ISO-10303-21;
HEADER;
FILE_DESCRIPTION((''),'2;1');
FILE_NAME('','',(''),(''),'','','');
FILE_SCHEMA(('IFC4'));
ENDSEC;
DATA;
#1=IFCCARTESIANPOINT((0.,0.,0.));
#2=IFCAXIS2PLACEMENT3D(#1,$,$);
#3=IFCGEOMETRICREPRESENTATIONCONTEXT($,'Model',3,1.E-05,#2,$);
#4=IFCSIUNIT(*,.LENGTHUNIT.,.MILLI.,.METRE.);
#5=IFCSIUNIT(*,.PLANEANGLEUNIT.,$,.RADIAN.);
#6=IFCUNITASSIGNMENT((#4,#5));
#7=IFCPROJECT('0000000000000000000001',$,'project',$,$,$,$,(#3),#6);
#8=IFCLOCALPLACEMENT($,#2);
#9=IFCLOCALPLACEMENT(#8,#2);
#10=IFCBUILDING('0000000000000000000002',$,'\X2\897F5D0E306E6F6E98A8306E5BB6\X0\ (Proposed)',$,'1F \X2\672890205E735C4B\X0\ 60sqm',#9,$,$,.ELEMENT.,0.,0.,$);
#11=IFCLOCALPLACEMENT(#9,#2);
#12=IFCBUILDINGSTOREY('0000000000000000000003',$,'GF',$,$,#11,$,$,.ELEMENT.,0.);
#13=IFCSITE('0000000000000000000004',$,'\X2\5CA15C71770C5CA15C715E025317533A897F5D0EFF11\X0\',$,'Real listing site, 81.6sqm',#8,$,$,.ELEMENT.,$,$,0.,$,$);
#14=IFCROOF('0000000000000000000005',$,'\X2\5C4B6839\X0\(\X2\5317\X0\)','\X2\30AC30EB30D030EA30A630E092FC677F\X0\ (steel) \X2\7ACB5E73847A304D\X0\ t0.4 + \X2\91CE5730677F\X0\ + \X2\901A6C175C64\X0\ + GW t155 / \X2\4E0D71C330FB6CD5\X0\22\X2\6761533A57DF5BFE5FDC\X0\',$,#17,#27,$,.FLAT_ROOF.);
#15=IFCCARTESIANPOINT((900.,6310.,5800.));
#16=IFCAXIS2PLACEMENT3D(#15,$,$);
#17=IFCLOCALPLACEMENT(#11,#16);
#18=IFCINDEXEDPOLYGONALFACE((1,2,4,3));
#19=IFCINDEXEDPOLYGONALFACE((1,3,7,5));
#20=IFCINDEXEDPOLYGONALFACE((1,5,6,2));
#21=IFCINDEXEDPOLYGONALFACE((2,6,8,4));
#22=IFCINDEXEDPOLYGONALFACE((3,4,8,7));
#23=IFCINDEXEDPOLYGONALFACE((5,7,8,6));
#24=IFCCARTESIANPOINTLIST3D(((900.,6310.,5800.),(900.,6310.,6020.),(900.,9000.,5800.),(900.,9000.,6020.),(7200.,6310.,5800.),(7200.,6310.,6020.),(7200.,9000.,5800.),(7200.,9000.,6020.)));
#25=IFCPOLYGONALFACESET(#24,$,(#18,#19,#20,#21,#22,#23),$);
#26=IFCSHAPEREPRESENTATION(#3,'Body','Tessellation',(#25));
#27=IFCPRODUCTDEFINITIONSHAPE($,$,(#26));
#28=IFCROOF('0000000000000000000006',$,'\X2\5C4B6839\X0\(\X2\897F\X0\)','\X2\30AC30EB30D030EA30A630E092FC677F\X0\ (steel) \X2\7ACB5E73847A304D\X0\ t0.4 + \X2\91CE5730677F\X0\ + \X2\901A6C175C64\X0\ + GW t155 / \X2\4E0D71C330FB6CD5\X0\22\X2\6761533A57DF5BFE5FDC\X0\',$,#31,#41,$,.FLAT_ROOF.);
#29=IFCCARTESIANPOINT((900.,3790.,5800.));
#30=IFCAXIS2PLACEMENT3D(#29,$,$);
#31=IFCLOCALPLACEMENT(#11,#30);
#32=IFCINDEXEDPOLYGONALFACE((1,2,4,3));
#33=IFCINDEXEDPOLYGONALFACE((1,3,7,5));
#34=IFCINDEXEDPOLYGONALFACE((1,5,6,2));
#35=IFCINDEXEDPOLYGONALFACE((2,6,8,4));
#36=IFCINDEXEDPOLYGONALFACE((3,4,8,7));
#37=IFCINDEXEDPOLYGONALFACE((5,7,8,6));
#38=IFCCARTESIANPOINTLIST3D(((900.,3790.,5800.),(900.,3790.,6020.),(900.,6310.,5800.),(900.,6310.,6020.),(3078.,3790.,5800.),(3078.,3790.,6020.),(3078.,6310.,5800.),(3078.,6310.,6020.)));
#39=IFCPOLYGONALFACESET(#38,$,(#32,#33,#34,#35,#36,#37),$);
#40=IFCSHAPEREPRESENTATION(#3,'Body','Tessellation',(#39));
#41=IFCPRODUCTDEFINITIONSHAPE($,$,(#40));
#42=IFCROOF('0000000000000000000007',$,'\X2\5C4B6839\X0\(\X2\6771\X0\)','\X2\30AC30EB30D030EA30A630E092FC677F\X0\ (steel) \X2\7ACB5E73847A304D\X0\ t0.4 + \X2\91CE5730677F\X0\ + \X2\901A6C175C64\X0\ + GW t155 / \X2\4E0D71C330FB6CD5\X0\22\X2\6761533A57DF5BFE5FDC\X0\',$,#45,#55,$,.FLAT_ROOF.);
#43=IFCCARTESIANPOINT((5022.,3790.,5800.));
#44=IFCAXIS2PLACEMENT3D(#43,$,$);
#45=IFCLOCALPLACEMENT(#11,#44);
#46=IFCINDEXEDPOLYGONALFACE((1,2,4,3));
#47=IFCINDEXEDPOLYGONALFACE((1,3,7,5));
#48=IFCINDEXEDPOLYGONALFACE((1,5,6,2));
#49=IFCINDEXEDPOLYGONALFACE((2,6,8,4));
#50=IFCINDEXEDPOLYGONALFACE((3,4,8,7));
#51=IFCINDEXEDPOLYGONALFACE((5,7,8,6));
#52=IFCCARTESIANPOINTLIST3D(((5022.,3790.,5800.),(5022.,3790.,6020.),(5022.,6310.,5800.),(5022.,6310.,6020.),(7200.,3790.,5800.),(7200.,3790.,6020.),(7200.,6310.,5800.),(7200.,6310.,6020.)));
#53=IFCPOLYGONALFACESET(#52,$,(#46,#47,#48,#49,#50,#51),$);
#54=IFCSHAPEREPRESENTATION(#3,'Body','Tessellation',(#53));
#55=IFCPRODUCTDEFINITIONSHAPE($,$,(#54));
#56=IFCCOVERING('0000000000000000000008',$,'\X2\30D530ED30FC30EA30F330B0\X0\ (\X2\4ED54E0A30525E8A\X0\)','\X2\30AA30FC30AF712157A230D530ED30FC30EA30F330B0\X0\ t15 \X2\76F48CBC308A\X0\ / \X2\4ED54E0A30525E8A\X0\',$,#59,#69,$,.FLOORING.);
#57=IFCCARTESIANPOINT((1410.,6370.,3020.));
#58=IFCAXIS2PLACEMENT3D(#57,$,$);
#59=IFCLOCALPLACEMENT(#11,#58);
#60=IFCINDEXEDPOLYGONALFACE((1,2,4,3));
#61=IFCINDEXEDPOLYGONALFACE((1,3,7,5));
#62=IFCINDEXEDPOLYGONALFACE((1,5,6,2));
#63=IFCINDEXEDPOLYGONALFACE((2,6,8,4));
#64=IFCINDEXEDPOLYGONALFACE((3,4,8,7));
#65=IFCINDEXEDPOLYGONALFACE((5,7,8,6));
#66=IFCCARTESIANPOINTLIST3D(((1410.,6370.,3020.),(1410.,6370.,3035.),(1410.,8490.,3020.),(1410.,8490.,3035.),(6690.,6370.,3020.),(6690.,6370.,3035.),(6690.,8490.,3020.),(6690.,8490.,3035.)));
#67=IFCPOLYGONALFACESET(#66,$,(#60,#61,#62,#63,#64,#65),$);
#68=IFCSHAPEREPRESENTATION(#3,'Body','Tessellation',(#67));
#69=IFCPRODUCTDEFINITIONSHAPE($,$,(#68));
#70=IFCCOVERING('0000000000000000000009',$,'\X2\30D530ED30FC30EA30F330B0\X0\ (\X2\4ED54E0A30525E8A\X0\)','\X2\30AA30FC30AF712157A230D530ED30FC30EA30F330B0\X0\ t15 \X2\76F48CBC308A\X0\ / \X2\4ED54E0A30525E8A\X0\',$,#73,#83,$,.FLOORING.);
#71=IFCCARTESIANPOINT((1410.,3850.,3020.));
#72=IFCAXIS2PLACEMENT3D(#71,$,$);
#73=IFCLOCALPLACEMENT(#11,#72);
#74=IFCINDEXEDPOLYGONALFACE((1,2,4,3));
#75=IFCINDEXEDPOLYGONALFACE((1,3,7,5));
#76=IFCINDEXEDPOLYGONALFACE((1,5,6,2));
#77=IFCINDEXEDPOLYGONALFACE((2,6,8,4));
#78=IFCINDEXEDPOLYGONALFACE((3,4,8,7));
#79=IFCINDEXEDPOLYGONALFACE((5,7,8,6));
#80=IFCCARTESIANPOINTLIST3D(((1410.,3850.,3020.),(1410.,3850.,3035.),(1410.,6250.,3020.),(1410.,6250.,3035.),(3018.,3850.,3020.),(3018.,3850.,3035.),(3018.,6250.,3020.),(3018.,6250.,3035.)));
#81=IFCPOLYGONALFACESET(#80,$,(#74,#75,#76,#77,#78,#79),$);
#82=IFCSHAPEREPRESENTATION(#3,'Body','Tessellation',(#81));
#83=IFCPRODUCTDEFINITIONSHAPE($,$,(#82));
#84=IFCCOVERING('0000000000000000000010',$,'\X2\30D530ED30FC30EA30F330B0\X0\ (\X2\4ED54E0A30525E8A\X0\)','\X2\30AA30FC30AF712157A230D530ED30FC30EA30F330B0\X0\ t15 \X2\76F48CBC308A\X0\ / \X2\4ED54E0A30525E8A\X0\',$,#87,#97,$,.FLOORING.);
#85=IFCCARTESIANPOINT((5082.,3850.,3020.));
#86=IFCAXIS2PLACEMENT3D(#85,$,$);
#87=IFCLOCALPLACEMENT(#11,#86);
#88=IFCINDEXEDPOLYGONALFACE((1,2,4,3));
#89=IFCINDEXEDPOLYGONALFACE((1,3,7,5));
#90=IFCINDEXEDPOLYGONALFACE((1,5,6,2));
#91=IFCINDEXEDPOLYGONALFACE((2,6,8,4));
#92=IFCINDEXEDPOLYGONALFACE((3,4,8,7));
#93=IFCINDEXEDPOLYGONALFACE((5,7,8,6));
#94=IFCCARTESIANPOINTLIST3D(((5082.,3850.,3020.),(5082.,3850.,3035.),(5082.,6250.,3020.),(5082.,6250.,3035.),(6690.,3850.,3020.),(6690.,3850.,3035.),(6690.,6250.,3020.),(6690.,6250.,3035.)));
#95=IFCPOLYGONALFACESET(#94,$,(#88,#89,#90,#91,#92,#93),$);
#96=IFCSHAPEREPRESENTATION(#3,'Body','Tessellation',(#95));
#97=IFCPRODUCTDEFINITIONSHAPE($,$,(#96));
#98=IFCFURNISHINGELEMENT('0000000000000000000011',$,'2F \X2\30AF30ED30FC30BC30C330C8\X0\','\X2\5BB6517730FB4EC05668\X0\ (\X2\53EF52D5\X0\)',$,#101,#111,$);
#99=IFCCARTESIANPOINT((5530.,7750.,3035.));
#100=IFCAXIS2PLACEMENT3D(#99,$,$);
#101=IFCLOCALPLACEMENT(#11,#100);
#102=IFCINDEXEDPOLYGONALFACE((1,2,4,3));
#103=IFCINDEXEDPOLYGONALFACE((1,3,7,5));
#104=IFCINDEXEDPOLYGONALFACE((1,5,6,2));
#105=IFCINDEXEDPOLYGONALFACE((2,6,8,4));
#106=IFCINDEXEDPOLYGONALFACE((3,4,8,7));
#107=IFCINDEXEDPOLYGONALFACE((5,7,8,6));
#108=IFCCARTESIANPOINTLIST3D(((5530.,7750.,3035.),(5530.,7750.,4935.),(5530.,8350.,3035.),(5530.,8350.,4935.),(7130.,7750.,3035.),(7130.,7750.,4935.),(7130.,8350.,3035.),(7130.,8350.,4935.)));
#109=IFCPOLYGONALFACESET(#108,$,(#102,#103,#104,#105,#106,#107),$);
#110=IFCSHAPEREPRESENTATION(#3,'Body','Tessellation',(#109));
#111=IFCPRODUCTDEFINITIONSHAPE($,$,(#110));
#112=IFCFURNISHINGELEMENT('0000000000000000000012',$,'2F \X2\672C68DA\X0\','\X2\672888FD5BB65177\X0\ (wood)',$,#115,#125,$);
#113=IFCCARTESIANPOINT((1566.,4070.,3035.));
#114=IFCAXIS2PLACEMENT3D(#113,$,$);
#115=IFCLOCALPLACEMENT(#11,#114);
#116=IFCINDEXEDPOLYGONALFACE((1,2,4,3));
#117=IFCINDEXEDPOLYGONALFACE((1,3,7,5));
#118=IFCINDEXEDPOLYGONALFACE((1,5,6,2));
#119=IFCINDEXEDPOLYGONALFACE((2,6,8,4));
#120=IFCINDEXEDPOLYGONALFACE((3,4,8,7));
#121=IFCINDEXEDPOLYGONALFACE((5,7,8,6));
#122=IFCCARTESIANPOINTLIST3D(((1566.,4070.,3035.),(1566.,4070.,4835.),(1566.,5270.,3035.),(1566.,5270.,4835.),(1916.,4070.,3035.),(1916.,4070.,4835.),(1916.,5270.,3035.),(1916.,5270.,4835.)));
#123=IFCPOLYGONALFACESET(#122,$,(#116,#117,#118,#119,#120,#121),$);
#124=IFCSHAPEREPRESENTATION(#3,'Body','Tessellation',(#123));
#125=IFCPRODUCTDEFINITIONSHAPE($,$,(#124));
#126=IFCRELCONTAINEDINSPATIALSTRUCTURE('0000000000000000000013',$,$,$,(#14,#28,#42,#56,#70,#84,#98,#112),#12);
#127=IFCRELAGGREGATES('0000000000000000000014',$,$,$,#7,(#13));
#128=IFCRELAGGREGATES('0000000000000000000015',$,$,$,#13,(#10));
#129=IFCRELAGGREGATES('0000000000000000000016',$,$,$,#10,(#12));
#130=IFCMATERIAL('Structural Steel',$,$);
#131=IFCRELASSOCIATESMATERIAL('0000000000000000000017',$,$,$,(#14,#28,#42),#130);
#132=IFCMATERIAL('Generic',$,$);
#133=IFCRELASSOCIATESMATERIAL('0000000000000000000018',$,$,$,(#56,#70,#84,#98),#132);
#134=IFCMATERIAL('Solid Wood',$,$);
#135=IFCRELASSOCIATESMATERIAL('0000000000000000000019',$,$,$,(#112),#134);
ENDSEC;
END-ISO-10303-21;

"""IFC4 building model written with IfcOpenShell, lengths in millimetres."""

from ifc_helpers import new_model, si_unit, frame, frame_2d, origin, place, context, project, spatial, rectangle, extrude, material, element, save


model = new_model("IFC4")

# Units and contexts
model_context = context("Model", 3, precision=1e-05, world=origin())
ifc_project = project(units=[si_unit("LENGTHUNIT", "METRE", prefix="MILLI"), si_unit("PLANEANGLEUNIT", "RADIAN")], contexts=[model_context])

# Site, building, storey
site_placement = place(None, origin())
site = spatial("IfcSite", under=ifc_project, at=site_placement, Name="岡山県岡山市北区西崎１", ObjectType="Real listing site, 81.6sqm", CompositionType="ELEMENT", RefElevation=0.0)
building_placement = place(site_placement, origin())
building = spatial("IfcBuilding", under=site, at=building_placement, Name="西崎の潮風の家 (Proposed)", ObjectType="1F 木造平屋 60sqm", CompositionType="ELEMENT", ElevationOfRefHeight=0.0, ElevationOfTerrain=0.0)
storey_placement = place(building_placement, origin())
storey = spatial("IfcBuildingStorey", under=building, at=storey_placement, Name="GF", CompositionType="ELEMENT", Elevation=0.0)

# Shared definitions
ifc_material_1 = material(Name="Solid Wood")

# Shared definitions
ifc_material_2 = material(Name="Generic")

# Roofs
ifc_material_3 = material(Name="Structural Steel")
for number, where, name in (
    (1, (900.0, 6310.0, 5800.0), "屋根(北)"),
):
    element("IfcRoof", number, at=place(storey_placement, frame(where)), inside=storey, material=ifc_material_3, Name=name, Description="ガルバリウム鋼板 (steel) 立平葺き t0.4 + 野地板 + 通気層 + GW t155 / 不燃・法22条区域対応", PredefinedType="FLAT_ROOF", context=model_context, shape_type="SweptSolid", body=[
        extrude(rectangle(XDim=6300.0, YDim=2690.0, at=frame_2d((3150.0, 1345.0))), frame((900.0, 6310.0, 5800.0)), (0.0, 0.0, 1.0), 220.0),
    ])
roof_1_placement = place(storey_placement, frame((900.0, 3790.0, 5800.0)))
element("IfcRoof", 2, at=roof_1_placement, inside=storey, material=ifc_material_3, Name="屋根(西)", Description="ガルバリウム鋼板 (steel) 立平葺き t0.4 + 野地板 + 通気層 + GW t155 / 不燃・法22条区域対応", PredefinedType="FLAT_ROOF", context=model_context, shape_type="SweptSolid", body=[
    extrude(rectangle(XDim=2178.0, YDim=2520.0, at=frame_2d((1089.0, 1260.0))), frame((900.0, 3790.0, 5800.0)), (0.0, 0.0, 1.0), 220.0),
])
roof_2_placement = place(storey_placement, frame((5022.0, 3790.0, 5800.0)))
element("IfcRoof", 3, at=roof_2_placement, inside=storey, material=ifc_material_3, Name="屋根(東)", Description="ガルバリウム鋼板 (steel) 立平葺き t0.4 + 野地板 + 通気層 + GW t155 / 不燃・法22条区域対応", PredefinedType="FLAT_ROOF", context=model_context, shape_type="SweptSolid", body=[
    extrude(rectangle(XDim=2178.0, YDim=2520.0, at=frame_2d((1089.0, 1260.0))), frame((5022.0, 3790.0, 5800.0)), (0.0, 0.0, 1.0), 220.0),
])

# Coverings
covering_1_placement = place(storey_placement, frame((1410.0, 6370.0, 3020.0)))
element("IfcCovering", 4, at=covering_1_placement, inside=storey, material=ifc_material_2, Name="フローリング (仕上げ床)", Description="オーク無垢フローリング t15 直貼り / 仕上げ床", PredefinedType="FLOORING", context=model_context, shape_type="SweptSolid", body=[
    extrude(rectangle(XDim=5280.0, YDim=2120.0, at=frame_2d((2640.0, 1060.0))), frame((1410.0, 6370.0, 3020.0)), (0.0, 0.0, 1.0), 15.0),
])
covering_2_placement = place(storey_placement, frame((1410.0, 3850.0, 3020.0)))
element("IfcCovering", 5, at=covering_2_placement, inside=storey, material=ifc_material_2, Name="フローリング (仕上げ床)", Description="オーク無垢フローリング t15 直貼り / 仕上げ床", PredefinedType="FLOORING", context=model_context, shape_type="SweptSolid", body=[
    extrude(rectangle(XDim=1608.0, YDim=2400.0, at=frame_2d((804.0, 1200.0))), frame((1410.0, 3850.0, 3020.0)), (0.0, 0.0, 1.0), 15.0),
])
covering_3_placement = place(storey_placement, frame((5082.0, 3850.0, 3020.0)))
element("IfcCovering", 6, at=covering_3_placement, inside=storey, material=ifc_material_2, Name="フローリング (仕上げ床)", Description="オーク無垢フローリング t15 直貼り / 仕上げ床", PredefinedType="FLOORING", context=model_context, shape_type="SweptSolid", body=[
    extrude(rectangle(XDim=1608.0, YDim=2400.0, at=frame_2d((804.0, 1200.0))), frame((5082.0, 3850.0, 3020.0)), (0.0, 0.0, 1.0), 15.0),
])

# Furnishing elements
furnishing_1_placement = place(storey_placement, frame((5530.0, 7750.0, 3035.0)))
element("IfcFurnishingElement", 7, at=furnishing_1_placement, inside=storey, material=ifc_material_2, Name="2F クローゼット", Description="家具・什器 (可動)", context=model_context, shape_type="SweptSolid", body=[
    extrude(rectangle(XDim=1600.0, YDim=600.0, at=frame_2d((800.0, 300.0))), frame((5530.0, 7750.0, 3035.0)), (0.0, 0.0, 1.0), 1900.0),
])
furnishing_2_placement = place(storey_placement, frame((1566.0, 4070.0, 3035.0)))
element("IfcFurnishingElement", 8, at=furnishing_2_placement, inside=storey, material=ifc_material_1, Name="2F 本棚", Description="木製家具 (wood)", context=model_context, shape_type="SweptSolid", body=[
    extrude(rectangle(XDim=350.0, YDim=1200.0, at=frame_2d((175.0, 600.0))), frame((1566.0, 4070.0, 3035.0)), (0.0, 0.0, 1.0), 1800.0),
])

save(model, "model.ifc")
